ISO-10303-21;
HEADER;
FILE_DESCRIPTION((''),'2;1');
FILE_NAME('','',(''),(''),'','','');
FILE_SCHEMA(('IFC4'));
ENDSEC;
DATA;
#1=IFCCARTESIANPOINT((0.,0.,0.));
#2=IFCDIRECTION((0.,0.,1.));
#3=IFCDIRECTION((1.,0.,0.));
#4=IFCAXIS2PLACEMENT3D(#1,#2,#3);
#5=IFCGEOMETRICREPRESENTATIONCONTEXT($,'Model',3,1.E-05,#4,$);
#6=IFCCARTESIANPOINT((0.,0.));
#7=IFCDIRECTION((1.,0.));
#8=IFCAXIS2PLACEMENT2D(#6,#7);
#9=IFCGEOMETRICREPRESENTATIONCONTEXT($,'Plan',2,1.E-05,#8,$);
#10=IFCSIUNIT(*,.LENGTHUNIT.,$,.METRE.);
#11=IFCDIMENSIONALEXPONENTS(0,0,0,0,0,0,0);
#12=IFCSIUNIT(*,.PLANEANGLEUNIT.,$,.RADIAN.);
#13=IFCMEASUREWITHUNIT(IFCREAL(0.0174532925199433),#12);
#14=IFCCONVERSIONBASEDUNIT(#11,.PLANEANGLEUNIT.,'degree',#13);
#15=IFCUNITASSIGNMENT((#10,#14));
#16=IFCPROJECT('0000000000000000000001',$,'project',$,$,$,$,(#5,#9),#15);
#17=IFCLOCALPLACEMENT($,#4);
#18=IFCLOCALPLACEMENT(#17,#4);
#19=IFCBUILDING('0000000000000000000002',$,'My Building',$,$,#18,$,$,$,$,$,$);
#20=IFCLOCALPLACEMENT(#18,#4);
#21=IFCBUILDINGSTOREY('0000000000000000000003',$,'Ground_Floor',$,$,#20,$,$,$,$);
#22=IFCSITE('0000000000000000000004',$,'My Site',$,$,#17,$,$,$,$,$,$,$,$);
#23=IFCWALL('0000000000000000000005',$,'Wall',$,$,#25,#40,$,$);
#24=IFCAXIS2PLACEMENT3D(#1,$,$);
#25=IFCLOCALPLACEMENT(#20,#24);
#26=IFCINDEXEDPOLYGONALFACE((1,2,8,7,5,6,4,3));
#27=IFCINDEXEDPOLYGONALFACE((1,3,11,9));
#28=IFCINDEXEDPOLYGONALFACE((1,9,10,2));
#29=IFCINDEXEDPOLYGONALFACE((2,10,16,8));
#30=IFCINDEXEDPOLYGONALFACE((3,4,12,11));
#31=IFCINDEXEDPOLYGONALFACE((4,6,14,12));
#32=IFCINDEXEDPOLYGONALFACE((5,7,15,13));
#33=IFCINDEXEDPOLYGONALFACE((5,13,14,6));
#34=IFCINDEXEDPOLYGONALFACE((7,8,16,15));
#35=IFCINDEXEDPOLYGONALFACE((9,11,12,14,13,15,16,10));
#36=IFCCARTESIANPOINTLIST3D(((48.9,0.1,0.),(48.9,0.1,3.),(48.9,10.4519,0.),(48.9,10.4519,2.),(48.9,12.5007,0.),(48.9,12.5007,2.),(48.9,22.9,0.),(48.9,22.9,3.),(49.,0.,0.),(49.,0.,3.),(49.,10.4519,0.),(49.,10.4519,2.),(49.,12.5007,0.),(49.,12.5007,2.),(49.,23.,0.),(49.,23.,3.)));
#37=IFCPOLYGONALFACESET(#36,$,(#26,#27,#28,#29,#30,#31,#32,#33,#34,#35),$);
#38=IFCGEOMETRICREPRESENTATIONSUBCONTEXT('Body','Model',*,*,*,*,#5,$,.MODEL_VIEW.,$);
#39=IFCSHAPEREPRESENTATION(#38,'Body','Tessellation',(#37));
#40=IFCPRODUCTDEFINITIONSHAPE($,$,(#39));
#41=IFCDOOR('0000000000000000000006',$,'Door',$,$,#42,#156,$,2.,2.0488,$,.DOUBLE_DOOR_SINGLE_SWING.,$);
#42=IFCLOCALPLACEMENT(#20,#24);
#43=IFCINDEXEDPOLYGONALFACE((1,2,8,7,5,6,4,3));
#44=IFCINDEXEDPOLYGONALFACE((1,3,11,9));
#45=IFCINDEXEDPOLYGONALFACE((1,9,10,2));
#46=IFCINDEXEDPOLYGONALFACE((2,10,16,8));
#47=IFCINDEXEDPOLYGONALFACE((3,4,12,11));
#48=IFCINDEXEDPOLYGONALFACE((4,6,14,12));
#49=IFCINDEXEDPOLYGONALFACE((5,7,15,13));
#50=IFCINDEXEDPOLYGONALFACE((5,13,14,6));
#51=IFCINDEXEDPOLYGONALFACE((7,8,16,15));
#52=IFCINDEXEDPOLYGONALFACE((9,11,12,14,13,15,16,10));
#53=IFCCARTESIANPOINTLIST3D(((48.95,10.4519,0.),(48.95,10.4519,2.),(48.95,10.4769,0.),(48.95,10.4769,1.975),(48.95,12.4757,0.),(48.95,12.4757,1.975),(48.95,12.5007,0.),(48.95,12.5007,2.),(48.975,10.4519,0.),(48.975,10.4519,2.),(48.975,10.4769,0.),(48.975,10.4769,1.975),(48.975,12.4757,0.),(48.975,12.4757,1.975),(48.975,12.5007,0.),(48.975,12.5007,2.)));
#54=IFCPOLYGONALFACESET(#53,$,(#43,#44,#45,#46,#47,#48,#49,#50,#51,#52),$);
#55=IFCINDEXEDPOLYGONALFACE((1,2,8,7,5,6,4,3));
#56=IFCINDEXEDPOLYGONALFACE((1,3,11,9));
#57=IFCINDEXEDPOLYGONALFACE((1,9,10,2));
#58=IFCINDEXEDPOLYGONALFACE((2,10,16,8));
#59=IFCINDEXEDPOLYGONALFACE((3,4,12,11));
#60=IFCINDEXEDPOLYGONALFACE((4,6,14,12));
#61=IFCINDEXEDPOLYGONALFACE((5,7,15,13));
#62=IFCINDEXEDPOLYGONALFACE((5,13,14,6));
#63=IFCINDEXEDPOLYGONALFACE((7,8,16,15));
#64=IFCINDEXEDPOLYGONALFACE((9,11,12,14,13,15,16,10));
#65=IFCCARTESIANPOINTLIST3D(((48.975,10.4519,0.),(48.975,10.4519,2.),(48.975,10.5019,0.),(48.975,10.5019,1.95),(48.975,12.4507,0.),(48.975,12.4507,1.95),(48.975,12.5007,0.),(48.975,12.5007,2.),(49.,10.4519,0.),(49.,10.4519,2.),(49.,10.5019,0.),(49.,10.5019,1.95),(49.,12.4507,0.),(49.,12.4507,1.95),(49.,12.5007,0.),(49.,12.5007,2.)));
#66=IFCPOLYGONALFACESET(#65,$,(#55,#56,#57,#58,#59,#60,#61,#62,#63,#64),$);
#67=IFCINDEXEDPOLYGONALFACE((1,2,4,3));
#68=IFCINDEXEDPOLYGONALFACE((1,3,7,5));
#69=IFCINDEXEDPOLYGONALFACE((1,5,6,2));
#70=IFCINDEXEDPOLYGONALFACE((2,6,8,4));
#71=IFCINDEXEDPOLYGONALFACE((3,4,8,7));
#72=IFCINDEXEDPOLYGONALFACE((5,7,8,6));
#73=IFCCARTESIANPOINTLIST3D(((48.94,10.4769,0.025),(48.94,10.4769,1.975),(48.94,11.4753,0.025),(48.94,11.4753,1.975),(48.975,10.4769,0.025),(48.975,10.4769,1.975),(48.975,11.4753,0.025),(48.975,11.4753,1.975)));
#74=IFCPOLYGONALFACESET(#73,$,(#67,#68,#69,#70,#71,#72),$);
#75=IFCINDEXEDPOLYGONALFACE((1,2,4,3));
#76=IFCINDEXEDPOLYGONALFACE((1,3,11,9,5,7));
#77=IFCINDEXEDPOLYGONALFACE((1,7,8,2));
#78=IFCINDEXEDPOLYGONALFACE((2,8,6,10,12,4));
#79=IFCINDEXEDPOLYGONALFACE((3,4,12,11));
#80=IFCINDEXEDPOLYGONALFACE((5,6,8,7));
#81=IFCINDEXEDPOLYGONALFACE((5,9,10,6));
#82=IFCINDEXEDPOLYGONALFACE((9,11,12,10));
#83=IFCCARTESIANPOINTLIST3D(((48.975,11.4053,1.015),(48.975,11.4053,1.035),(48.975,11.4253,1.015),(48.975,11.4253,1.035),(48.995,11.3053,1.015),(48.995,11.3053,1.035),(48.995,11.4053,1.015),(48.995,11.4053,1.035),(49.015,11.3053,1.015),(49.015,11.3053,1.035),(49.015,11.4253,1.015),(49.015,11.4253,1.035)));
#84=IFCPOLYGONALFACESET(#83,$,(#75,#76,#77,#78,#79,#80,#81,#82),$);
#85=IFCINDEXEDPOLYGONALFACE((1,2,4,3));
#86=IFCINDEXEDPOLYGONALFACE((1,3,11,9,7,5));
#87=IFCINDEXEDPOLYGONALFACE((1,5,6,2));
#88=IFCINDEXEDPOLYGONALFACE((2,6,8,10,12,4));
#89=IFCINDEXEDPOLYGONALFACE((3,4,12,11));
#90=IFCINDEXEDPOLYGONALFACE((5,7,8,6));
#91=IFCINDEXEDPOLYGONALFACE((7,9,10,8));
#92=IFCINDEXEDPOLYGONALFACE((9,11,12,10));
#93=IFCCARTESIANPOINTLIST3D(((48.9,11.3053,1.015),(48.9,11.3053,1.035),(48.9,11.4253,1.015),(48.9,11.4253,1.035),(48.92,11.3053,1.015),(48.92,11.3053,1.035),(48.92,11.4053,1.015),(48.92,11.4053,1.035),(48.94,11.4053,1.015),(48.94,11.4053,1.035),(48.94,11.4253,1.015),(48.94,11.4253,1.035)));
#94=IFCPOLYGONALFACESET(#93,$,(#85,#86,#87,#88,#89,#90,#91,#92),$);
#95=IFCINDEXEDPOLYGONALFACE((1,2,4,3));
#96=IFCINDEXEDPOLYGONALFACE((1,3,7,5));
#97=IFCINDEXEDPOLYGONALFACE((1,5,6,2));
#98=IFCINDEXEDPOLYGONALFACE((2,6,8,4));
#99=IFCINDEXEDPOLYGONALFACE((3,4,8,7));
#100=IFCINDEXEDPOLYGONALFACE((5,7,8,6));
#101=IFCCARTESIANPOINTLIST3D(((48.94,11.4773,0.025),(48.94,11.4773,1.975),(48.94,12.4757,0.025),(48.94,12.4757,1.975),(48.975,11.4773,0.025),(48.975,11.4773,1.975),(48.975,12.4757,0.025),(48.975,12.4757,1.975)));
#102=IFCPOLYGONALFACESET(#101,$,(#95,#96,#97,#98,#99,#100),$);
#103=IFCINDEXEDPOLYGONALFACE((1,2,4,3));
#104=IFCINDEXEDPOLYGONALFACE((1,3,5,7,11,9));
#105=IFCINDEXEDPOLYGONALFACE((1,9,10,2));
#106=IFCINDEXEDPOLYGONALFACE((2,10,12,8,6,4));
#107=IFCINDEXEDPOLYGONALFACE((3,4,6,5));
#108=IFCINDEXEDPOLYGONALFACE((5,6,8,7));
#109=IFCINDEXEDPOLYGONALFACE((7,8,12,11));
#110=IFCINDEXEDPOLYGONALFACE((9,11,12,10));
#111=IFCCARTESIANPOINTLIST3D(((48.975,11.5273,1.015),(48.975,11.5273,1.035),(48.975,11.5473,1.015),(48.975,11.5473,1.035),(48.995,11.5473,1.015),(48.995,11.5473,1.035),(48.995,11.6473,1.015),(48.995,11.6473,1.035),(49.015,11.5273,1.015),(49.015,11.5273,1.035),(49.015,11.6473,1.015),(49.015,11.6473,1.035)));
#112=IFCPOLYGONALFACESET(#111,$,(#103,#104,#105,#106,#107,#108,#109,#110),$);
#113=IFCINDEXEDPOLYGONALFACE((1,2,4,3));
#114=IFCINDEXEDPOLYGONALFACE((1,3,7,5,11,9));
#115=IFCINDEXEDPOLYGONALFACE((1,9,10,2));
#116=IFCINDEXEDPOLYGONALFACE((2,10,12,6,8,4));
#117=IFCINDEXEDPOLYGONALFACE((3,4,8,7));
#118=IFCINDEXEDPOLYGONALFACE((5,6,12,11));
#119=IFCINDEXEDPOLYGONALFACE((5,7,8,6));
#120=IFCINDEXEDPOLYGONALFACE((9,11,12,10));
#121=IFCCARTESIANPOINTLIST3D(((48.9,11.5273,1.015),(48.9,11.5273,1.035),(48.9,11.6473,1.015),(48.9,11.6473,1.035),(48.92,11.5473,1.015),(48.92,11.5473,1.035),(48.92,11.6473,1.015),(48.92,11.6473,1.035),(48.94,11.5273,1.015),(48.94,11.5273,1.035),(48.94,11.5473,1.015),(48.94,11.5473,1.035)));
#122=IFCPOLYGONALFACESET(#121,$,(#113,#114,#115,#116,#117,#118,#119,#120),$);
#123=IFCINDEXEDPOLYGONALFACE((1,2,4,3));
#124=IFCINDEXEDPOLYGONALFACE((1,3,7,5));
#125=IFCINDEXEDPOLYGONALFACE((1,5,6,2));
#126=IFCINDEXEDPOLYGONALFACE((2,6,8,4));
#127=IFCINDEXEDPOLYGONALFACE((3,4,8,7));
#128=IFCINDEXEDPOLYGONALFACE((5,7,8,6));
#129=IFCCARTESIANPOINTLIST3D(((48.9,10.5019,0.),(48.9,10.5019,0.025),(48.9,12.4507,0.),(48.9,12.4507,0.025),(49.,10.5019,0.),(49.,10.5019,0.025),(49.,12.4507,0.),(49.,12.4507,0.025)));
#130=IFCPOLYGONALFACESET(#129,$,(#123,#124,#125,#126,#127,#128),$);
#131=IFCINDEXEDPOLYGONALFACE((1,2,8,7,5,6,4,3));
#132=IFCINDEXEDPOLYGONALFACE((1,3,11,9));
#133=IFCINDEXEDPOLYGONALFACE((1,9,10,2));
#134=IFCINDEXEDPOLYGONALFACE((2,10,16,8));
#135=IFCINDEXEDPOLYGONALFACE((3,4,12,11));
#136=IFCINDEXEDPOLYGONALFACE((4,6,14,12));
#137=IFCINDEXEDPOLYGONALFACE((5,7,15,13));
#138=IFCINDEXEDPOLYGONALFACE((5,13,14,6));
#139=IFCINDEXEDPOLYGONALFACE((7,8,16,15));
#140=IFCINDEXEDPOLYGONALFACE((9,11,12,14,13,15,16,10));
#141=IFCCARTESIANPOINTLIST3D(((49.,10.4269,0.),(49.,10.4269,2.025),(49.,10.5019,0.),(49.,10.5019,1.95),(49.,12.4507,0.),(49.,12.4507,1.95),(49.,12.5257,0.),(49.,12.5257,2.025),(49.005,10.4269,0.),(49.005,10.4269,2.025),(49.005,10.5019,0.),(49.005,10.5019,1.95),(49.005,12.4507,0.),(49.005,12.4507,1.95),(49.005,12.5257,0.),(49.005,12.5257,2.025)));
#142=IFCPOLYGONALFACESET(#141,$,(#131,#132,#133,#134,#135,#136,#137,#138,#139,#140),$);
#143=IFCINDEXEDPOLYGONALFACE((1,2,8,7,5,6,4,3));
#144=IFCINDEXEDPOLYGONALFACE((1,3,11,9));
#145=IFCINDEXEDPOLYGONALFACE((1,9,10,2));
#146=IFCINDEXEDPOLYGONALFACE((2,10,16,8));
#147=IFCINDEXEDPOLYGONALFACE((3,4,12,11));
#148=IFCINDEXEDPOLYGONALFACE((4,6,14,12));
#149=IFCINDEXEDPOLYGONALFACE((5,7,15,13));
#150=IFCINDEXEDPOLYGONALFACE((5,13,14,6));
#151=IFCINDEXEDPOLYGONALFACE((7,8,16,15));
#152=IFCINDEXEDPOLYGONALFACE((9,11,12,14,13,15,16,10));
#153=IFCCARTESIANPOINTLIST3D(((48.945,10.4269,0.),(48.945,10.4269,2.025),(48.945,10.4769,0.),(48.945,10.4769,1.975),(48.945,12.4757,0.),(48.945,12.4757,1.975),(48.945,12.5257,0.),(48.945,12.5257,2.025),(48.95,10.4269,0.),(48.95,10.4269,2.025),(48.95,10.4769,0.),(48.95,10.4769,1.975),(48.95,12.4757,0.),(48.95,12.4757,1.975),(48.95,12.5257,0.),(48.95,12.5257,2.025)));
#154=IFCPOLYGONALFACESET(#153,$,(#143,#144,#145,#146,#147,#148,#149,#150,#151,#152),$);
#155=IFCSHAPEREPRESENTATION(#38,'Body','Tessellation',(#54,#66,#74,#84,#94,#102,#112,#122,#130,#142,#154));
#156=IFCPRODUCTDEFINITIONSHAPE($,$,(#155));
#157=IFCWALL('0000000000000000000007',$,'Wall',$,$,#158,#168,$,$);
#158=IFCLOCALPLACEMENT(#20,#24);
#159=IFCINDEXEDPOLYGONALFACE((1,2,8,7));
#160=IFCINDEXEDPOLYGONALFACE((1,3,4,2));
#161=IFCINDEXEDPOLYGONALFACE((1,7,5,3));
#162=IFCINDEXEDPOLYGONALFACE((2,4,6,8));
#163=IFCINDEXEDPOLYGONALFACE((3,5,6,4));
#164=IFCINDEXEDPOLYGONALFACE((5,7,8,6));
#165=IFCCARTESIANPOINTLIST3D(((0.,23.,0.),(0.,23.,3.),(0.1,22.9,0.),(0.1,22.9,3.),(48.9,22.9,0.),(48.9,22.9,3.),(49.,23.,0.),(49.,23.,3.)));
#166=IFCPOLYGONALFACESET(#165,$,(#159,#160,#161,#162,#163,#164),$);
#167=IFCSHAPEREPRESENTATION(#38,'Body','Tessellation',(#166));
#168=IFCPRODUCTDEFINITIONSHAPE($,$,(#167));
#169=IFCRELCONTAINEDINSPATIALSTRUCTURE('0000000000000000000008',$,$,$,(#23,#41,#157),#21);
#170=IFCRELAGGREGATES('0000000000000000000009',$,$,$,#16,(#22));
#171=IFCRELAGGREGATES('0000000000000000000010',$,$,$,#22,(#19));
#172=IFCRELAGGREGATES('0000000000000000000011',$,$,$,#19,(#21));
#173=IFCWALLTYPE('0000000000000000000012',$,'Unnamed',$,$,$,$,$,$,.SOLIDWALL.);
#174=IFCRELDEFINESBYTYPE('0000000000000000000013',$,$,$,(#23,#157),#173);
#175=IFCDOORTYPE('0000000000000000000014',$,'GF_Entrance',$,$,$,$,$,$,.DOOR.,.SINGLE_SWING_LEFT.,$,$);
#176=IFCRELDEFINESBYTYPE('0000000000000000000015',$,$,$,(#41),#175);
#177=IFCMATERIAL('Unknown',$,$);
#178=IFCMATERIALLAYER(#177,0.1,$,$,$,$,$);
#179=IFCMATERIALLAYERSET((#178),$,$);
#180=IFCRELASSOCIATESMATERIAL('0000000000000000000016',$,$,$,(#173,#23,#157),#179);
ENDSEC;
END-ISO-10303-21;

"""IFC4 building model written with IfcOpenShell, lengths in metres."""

from ifc_helpers import new_model, entity, si_unit, converted_unit, frame, origin_with_axes, origin_2d_with_axis, place, context, subcontext, project, spatial, line, indexed_curve, outline, extrude, shape, source, transform, mapped, material, layer, layer_set, layer_usage, type_object, type_shapes, element, fill, save


model = new_model("IFC4")

# Units and contexts
model_context = context("Model", 3, precision=1e-05, world=origin_with_axes())
plan_context = context("Plan", 2, precision=1e-05, world=origin_2d_with_axis())
body_context_1 = subcontext(model_context, "Body", "Model", "MODEL_VIEW")
body_context_2 = subcontext(plan_context, "Body", "Plan", "PLAN_VIEW")
ifc_project = project(units=[si_unit("LENGTHUNIT", "METRE"), converted_unit("PLANEANGLEUNIT", "degree", entity("IfcReal", 0.0174532925199433), si_unit("PLANEANGLEUNIT", "RADIAN"), dimensions=[0, 0, 0, 0, 0, 0, 0])], contexts=[model_context, plan_context])

# Site, building, storey
site_placement = place(None, origin_with_axes())
site = spatial("IfcSite", under=ifc_project, at=site_placement, Name="My Site")
building_placement = place(site_placement, origin_with_axes())
building = spatial("IfcBuilding", under=site, at=building_placement, Name="My Building")
storey_placement = place(building_placement, origin_with_axes())
storey = spatial("IfcBuildingStorey", under=building, at=storey_placement, Name="Ground_Floor")

# Shared definitions
ifc_material = material(Name="Unknown")
ifc_layer = layer(ifc_material, 0.1)
ifc_layer_set = layer_set([ifc_layer])
wall_type = type_object("IfcWallType", Name="Unnamed", PredefinedType="SOLIDWALL", material=ifc_layer_set)

# Shared definitions
shared_shape_1 = source(origin_with_axes(), body_context_1, "Body", "SweptSolid", [
    extrude(outline(indexed_curve([(0.0, 0.0), (2.0488, 0.0), (2.0488, 2.0), (0.0, 2.0)], segments=[line(1, 2, 3, 4, 1)])), frame((0.0, -0.6, 0.0), z_axis=(0.0, -1.0, 0.0), x_axis=(1.0, 0.0, 0.0)), (0.0, 0.0, -1.0), 1.2),
])
door_type_1 = type_object("IfcDoorType", Name="GF_Entrance", OperationType="SINGLE_SWING_LEFT", PredefinedType="DOOR")
shared_shape_2 = source(origin_with_axes(), body_context_1, "Body", "SweptSolid", [
    extrude(outline(indexed_curve([(0.0, 0.0), (0.0, 2.0), (2.0488, 2.0), (2.0488, 0.0), (2.0238, 0.0), (2.0238, 1.975), (0.025, 1.975), (0.025, 0.0)], segments=[line(1, 2, 3, 4, 5, 6, 7, 8, 1)])), frame((0.0, 0.025, 0.0), z_axis=(0.0, -1.0, 0.0), x_axis=(1.0, 0.0, 0.0)), (0.0, 0.0, -1.0), 0.025),
    extrude(outline(indexed_curve([(0.0, 0.0), (0.0, 2.0), (2.0488, 2.0), (2.0488, 0.0), (1.9988, 0.0), (1.9988, 1.95), (0.05, 1.95), (0.05, 0.0)], segments=[line(1, 2, 3, 4, 5, 6, 7, 8, 1)])), frame((0.0, 0.0, 0.0), z_axis=(0.0, -1.0, 0.0), x_axis=(1.0, 0.0, 0.0)), (0.0, 0.0, -1.0), 0.025),
    extrude(outline(indexed_curve([(0.0, 0.0), (0.9984, 0.0), (0.9984, 0.035), (0.0, 0.035)], segments=[line(1, 2, 3, 4, 1)])), frame((0.025, 0.025, 0.025), z_axis=(0.0, 0.0, 1.0), x_axis=(1.0, 0.0, 0.0)), (0.0, 0.0, 1.0), 1.95),
    extrude(outline(indexed_curve([(0.0, 0.0), (0.0, -0.04), (-0.12, -0.04), (-0.12, -0.02), (-0.02, -0.02), (-0.02, 0.0)], segments=[line(1, 2, 3, 4, 5, 6, 1)])), frame((0.9734, 0.025, 1.015), z_axis=(0.0, 0.0, 1.0), x_axis=(1.0, 0.0, 0.0)), (0.0, 0.0, 1.0), 0.02),
    extrude(outline(indexed_curve([(0.0, 0.0), (0.0, 0.04), (-0.12, 0.04), (-0.12, 0.02), (-0.02, 0.02), (-0.02, 0.0)], segments=[line(1, 2, 3, 4, 5, 6, 1)])), frame((0.9734, 0.06, 1.015), z_axis=(0.0, 0.0, 1.0), x_axis=(1.0, 0.0, 0.0)), (0.0, 0.0, 1.0), 0.02),
    extrude(outline(indexed_curve([(0.0, 0.0), (-0.9984, 0.0), (-0.9984, 0.035), (0.0, 0.035)], segments=[line(1, 2, 3, 4, 1)])), frame((2.0238, 0.025, 0.025), z_axis=(0.0, 0.0, 1.0), x_axis=(1.0, 0.0, 0.0)), (0.0, 0.0, 1.0), 1.95),
    extrude(outline(indexed_curve([(0.0, 0.0), (0.0, -0.04), (0.12, -0.04), (0.12, -0.02), (0.02, -0.02), (0.02, 0.0)], segments=[line(1, 2, 3, 4, 5, 6, 1)])), frame((1.0754, 0.025, 1.015), z_axis=(0.0, 0.0, 1.0), x_axis=(1.0, 0.0, 0.0)), (0.0, 0.0, 1.0), 0.02),
    extrude(outline(indexed_curve([(0.0, 0.0), (0.0, 0.04), (0.12, 0.04), (0.12, 0.02), (0.02, 0.02), (0.02, 0.0)], segments=[line(1, 2, 3, 4, 5, 6, 1)])), frame((1.0754, 0.06, 1.015), z_axis=(0.0, 0.0, 1.0), x_axis=(1.0, 0.0, 0.0)), (0.0, 0.0, 1.0), 0.02),
    extrude(outline(indexed_curve([(0.0, 0.0), (1.9488, 0.0), (1.9488, 0.1), (0.0, 0.1)], segments=[line(1, 2, 3, 4, 1)])), frame((0.05, 0.0, 0.0), z_axis=(0.0, 0.0, 1.0), x_axis=(1.0, 0.0, 0.0)), (0.0, 0.0, 1.0), 0.025),
    extrude(outline(indexed_curve([(0.0, 0.0), (0.0, 2.025), (2.0988, 2.025), (2.0988, 0.0), (2.0238, 0.0), (2.0238, 1.95), (0.075, 1.95), (0.075, 0.0)], segments=[line(1, 2, 3, 4, 5, 6, 7, 8, 1)])), frame((-0.025, -0.005, 0.0), z_axis=(0.0, -1.0, 0.0), x_axis=(1.0, 0.0, 0.0)), (0.0, 0.0, -1.0), 0.005),
    extrude(outline(indexed_curve([(0.0, 0.0), (0.0, 2.025), (2.0988, 2.025), (2.0988, 0.0), (2.0488, 0.0), (2.0488, 1.975), (0.05, 1.975), (0.05, 0.0)], segments=[line(1, 2, 3, 4, 5, 6, 7, 8, 1)])), frame((-0.025, 0.05, 0.0), z_axis=(0.0, -1.0, 0.0), x_axis=(1.0, 0.0, 0.0)), (0.0, 0.0, -1.0), 0.005),
])
shared_shape_3 = source(origin_with_axes(), body_context_2, "Body", "Curve2D", [
    entity("IfcIndexedPolyCurve", entity("IfcCartesianPointList2D", [[0.0, 0.0], [0.0, 0.05], [0.025, 0.05], [0.025, 0.025], [0.05, 0.025], [0.05, 0.0]]), [entity("IfcLineIndex", [1, 2, 3, 4, 5, 6, 1])]),
    entity("IfcIndexedPolyCurve", entity("IfcCartesianPointList2D", [[2.0488, 0.0], [2.0488, 0.05], [2.0238, 0.05], [2.0238, 0.025], [1.9988, 0.025], [1.9988, 0.0]]), [entity("IfcLineIndex", [1, 2, 3, 4, 5, 6, 1])]),
    entity("IfcTrimmedCurve", entity("IfcEllipse", entity("IfcAxis2Placement2D", entity("IfcCartesianPoint", [0.06, 0.05]), entity("IfcDirection", [1.0, 0.0])), 0.9644, 0.9994), [entity("IfcCartesianPoint", [1.0244, 0.05])], [entity("IfcCartesianPoint", [0.06, 1.0494])], True, "CARTESIAN"),
    entity("IfcIndexedPolyCurve", entity("IfcCartesianPointList2D", [[0.025, 0.05], [0.06, 0.05], [0.06, 1.0494], [0.025, 1.0494]]), [entity("IfcLineIndex", [1, 2, 3, 4, 1])]),
    entity("IfcTrimmedCurve", entity("IfcEllipse", entity("IfcAxis2Placement2D", entity("IfcCartesianPoint", [1.9888, 0.05]), entity("IfcDirection", [1.0, 0.0])), 0.9644, 0.9994), [entity("IfcCartesianPoint", [1.9888, 1.0494])], [entity("IfcCartesianPoint", [1.0244, 0.05])], True, "CARTESIAN"),
    entity("IfcIndexedPolyCurve", entity("IfcCartesianPointList2D", [[2.0238, 0.05], [1.9888, 0.05], [1.9888, 1.0494], [2.0238, 1.0494]]), [entity("IfcLineIndex", [1, 2, 3, 4, 1])]),
])
type_shapes(door_type_1, [shared_shape_2, shared_shape_3])

# Wall, opening, door
ifc_layer_usage_1 = layer_usage(ifc_layer_set, "AXIS2", "POSITIVE", 0.0)
wall_1_placement = place(storey_placement, frame((49.0, 0.0, 0.0), z_axis=(0.0, 0.0, 1.0), x_axis=(0.0, 1.0, 0.0)))
wall_1 = element("IfcWall", 1, at=wall_1_placement, inside=storey, type_object=wall_type, material=ifc_layer_usage_1, Name="Wall", context=body_context_1, shape_type="SweptSolid", body=[
    extrude(outline(indexed_curve([(0.0, 0.0), (0.1, 0.1), (22.9, 0.1), (23.0, 0.0)], segments=[line(1, 2, 3, 4, 1)])), origin_with_axes(), (0.0, 0.0, 1.0), 3.0),
])
opening_1_placement = place(wall_1_placement, frame((10.4519, 0.0, 0.0), z_axis=(0.0, 0.0, 1.0), x_axis=(1.0, 0.0, 0.0)))
opening_1 = element("IfcOpeningElement", 2, at=opening_1_placement, cuts=wall_1, PredefinedType="OPENING", context=body_context_1, shape_type="MappedRepresentation", body=[
    mapped(shared_shape_1, transform((0.0, 0.0, 0.0), x_axis=(1.0, 0.0, 0.0), y_axis=(0.0, 1.0, 0.0), z_axis=(0.0, 0.0, 1.0), scale=1.0)),
])
door_1_placement = place(opening_1_placement, origin_with_axes())
door_1 = element("IfcDoor", 3, at=door_1_placement, inside=storey, type_object=door_type_1, Name="Door", OperationType="DOUBLE_DOOR_SINGLE_SWING", OverallHeight=2.0, OverallWidth=2.0488, shapes=[
    shape(body_context_1, "Body", "MappedRepresentation", [mapped(shared_shape_2, transform((0.0, 0.0, 0.0), x_axis=(1.0, 0.0, 0.0), y_axis=(0.0, 1.0, 0.0), z_axis=(0.0, 0.0, 1.0), scale=1.0))]),
    shape(body_context_2, "Body", "MappedRepresentation", [mapped(shared_shape_3, transform((0.0, 0.0, 0.0), x_axis=(1.0, 0.0, 0.0), y_axis=(0.0, 1.0, 0.0), z_axis=(0.0, 0.0, 1.0), scale=1.0))]),
])
fill(opening_1, door_1)

# Wall
ifc_layer_usage_2 = layer_usage(ifc_layer_set, "AXIS2", "POSITIVE", 0.0)
wall_2_placement = place(storey_placement, frame((49.0, 23.0, 0.0), z_axis=(0.0, 0.0, 1.0), x_axis=(-1.0, 0.0, 0.0)))
element("IfcWall", 4, at=wall_2_placement, inside=storey, type_object=wall_type, material=ifc_layer_usage_2, Name="Wall", context=body_context_1, shape_type="SweptSolid", body=[
    extrude(outline(indexed_curve([(0.0, 0.0), (0.1, 0.1), (48.9, 0.1), (49.0, 0.0)], segments=[line(1, 2, 3, 4, 1)])), origin_with_axes(), (0.0, 0.0, 1.0), 3.0),
])

save(model, "model.ifc")
